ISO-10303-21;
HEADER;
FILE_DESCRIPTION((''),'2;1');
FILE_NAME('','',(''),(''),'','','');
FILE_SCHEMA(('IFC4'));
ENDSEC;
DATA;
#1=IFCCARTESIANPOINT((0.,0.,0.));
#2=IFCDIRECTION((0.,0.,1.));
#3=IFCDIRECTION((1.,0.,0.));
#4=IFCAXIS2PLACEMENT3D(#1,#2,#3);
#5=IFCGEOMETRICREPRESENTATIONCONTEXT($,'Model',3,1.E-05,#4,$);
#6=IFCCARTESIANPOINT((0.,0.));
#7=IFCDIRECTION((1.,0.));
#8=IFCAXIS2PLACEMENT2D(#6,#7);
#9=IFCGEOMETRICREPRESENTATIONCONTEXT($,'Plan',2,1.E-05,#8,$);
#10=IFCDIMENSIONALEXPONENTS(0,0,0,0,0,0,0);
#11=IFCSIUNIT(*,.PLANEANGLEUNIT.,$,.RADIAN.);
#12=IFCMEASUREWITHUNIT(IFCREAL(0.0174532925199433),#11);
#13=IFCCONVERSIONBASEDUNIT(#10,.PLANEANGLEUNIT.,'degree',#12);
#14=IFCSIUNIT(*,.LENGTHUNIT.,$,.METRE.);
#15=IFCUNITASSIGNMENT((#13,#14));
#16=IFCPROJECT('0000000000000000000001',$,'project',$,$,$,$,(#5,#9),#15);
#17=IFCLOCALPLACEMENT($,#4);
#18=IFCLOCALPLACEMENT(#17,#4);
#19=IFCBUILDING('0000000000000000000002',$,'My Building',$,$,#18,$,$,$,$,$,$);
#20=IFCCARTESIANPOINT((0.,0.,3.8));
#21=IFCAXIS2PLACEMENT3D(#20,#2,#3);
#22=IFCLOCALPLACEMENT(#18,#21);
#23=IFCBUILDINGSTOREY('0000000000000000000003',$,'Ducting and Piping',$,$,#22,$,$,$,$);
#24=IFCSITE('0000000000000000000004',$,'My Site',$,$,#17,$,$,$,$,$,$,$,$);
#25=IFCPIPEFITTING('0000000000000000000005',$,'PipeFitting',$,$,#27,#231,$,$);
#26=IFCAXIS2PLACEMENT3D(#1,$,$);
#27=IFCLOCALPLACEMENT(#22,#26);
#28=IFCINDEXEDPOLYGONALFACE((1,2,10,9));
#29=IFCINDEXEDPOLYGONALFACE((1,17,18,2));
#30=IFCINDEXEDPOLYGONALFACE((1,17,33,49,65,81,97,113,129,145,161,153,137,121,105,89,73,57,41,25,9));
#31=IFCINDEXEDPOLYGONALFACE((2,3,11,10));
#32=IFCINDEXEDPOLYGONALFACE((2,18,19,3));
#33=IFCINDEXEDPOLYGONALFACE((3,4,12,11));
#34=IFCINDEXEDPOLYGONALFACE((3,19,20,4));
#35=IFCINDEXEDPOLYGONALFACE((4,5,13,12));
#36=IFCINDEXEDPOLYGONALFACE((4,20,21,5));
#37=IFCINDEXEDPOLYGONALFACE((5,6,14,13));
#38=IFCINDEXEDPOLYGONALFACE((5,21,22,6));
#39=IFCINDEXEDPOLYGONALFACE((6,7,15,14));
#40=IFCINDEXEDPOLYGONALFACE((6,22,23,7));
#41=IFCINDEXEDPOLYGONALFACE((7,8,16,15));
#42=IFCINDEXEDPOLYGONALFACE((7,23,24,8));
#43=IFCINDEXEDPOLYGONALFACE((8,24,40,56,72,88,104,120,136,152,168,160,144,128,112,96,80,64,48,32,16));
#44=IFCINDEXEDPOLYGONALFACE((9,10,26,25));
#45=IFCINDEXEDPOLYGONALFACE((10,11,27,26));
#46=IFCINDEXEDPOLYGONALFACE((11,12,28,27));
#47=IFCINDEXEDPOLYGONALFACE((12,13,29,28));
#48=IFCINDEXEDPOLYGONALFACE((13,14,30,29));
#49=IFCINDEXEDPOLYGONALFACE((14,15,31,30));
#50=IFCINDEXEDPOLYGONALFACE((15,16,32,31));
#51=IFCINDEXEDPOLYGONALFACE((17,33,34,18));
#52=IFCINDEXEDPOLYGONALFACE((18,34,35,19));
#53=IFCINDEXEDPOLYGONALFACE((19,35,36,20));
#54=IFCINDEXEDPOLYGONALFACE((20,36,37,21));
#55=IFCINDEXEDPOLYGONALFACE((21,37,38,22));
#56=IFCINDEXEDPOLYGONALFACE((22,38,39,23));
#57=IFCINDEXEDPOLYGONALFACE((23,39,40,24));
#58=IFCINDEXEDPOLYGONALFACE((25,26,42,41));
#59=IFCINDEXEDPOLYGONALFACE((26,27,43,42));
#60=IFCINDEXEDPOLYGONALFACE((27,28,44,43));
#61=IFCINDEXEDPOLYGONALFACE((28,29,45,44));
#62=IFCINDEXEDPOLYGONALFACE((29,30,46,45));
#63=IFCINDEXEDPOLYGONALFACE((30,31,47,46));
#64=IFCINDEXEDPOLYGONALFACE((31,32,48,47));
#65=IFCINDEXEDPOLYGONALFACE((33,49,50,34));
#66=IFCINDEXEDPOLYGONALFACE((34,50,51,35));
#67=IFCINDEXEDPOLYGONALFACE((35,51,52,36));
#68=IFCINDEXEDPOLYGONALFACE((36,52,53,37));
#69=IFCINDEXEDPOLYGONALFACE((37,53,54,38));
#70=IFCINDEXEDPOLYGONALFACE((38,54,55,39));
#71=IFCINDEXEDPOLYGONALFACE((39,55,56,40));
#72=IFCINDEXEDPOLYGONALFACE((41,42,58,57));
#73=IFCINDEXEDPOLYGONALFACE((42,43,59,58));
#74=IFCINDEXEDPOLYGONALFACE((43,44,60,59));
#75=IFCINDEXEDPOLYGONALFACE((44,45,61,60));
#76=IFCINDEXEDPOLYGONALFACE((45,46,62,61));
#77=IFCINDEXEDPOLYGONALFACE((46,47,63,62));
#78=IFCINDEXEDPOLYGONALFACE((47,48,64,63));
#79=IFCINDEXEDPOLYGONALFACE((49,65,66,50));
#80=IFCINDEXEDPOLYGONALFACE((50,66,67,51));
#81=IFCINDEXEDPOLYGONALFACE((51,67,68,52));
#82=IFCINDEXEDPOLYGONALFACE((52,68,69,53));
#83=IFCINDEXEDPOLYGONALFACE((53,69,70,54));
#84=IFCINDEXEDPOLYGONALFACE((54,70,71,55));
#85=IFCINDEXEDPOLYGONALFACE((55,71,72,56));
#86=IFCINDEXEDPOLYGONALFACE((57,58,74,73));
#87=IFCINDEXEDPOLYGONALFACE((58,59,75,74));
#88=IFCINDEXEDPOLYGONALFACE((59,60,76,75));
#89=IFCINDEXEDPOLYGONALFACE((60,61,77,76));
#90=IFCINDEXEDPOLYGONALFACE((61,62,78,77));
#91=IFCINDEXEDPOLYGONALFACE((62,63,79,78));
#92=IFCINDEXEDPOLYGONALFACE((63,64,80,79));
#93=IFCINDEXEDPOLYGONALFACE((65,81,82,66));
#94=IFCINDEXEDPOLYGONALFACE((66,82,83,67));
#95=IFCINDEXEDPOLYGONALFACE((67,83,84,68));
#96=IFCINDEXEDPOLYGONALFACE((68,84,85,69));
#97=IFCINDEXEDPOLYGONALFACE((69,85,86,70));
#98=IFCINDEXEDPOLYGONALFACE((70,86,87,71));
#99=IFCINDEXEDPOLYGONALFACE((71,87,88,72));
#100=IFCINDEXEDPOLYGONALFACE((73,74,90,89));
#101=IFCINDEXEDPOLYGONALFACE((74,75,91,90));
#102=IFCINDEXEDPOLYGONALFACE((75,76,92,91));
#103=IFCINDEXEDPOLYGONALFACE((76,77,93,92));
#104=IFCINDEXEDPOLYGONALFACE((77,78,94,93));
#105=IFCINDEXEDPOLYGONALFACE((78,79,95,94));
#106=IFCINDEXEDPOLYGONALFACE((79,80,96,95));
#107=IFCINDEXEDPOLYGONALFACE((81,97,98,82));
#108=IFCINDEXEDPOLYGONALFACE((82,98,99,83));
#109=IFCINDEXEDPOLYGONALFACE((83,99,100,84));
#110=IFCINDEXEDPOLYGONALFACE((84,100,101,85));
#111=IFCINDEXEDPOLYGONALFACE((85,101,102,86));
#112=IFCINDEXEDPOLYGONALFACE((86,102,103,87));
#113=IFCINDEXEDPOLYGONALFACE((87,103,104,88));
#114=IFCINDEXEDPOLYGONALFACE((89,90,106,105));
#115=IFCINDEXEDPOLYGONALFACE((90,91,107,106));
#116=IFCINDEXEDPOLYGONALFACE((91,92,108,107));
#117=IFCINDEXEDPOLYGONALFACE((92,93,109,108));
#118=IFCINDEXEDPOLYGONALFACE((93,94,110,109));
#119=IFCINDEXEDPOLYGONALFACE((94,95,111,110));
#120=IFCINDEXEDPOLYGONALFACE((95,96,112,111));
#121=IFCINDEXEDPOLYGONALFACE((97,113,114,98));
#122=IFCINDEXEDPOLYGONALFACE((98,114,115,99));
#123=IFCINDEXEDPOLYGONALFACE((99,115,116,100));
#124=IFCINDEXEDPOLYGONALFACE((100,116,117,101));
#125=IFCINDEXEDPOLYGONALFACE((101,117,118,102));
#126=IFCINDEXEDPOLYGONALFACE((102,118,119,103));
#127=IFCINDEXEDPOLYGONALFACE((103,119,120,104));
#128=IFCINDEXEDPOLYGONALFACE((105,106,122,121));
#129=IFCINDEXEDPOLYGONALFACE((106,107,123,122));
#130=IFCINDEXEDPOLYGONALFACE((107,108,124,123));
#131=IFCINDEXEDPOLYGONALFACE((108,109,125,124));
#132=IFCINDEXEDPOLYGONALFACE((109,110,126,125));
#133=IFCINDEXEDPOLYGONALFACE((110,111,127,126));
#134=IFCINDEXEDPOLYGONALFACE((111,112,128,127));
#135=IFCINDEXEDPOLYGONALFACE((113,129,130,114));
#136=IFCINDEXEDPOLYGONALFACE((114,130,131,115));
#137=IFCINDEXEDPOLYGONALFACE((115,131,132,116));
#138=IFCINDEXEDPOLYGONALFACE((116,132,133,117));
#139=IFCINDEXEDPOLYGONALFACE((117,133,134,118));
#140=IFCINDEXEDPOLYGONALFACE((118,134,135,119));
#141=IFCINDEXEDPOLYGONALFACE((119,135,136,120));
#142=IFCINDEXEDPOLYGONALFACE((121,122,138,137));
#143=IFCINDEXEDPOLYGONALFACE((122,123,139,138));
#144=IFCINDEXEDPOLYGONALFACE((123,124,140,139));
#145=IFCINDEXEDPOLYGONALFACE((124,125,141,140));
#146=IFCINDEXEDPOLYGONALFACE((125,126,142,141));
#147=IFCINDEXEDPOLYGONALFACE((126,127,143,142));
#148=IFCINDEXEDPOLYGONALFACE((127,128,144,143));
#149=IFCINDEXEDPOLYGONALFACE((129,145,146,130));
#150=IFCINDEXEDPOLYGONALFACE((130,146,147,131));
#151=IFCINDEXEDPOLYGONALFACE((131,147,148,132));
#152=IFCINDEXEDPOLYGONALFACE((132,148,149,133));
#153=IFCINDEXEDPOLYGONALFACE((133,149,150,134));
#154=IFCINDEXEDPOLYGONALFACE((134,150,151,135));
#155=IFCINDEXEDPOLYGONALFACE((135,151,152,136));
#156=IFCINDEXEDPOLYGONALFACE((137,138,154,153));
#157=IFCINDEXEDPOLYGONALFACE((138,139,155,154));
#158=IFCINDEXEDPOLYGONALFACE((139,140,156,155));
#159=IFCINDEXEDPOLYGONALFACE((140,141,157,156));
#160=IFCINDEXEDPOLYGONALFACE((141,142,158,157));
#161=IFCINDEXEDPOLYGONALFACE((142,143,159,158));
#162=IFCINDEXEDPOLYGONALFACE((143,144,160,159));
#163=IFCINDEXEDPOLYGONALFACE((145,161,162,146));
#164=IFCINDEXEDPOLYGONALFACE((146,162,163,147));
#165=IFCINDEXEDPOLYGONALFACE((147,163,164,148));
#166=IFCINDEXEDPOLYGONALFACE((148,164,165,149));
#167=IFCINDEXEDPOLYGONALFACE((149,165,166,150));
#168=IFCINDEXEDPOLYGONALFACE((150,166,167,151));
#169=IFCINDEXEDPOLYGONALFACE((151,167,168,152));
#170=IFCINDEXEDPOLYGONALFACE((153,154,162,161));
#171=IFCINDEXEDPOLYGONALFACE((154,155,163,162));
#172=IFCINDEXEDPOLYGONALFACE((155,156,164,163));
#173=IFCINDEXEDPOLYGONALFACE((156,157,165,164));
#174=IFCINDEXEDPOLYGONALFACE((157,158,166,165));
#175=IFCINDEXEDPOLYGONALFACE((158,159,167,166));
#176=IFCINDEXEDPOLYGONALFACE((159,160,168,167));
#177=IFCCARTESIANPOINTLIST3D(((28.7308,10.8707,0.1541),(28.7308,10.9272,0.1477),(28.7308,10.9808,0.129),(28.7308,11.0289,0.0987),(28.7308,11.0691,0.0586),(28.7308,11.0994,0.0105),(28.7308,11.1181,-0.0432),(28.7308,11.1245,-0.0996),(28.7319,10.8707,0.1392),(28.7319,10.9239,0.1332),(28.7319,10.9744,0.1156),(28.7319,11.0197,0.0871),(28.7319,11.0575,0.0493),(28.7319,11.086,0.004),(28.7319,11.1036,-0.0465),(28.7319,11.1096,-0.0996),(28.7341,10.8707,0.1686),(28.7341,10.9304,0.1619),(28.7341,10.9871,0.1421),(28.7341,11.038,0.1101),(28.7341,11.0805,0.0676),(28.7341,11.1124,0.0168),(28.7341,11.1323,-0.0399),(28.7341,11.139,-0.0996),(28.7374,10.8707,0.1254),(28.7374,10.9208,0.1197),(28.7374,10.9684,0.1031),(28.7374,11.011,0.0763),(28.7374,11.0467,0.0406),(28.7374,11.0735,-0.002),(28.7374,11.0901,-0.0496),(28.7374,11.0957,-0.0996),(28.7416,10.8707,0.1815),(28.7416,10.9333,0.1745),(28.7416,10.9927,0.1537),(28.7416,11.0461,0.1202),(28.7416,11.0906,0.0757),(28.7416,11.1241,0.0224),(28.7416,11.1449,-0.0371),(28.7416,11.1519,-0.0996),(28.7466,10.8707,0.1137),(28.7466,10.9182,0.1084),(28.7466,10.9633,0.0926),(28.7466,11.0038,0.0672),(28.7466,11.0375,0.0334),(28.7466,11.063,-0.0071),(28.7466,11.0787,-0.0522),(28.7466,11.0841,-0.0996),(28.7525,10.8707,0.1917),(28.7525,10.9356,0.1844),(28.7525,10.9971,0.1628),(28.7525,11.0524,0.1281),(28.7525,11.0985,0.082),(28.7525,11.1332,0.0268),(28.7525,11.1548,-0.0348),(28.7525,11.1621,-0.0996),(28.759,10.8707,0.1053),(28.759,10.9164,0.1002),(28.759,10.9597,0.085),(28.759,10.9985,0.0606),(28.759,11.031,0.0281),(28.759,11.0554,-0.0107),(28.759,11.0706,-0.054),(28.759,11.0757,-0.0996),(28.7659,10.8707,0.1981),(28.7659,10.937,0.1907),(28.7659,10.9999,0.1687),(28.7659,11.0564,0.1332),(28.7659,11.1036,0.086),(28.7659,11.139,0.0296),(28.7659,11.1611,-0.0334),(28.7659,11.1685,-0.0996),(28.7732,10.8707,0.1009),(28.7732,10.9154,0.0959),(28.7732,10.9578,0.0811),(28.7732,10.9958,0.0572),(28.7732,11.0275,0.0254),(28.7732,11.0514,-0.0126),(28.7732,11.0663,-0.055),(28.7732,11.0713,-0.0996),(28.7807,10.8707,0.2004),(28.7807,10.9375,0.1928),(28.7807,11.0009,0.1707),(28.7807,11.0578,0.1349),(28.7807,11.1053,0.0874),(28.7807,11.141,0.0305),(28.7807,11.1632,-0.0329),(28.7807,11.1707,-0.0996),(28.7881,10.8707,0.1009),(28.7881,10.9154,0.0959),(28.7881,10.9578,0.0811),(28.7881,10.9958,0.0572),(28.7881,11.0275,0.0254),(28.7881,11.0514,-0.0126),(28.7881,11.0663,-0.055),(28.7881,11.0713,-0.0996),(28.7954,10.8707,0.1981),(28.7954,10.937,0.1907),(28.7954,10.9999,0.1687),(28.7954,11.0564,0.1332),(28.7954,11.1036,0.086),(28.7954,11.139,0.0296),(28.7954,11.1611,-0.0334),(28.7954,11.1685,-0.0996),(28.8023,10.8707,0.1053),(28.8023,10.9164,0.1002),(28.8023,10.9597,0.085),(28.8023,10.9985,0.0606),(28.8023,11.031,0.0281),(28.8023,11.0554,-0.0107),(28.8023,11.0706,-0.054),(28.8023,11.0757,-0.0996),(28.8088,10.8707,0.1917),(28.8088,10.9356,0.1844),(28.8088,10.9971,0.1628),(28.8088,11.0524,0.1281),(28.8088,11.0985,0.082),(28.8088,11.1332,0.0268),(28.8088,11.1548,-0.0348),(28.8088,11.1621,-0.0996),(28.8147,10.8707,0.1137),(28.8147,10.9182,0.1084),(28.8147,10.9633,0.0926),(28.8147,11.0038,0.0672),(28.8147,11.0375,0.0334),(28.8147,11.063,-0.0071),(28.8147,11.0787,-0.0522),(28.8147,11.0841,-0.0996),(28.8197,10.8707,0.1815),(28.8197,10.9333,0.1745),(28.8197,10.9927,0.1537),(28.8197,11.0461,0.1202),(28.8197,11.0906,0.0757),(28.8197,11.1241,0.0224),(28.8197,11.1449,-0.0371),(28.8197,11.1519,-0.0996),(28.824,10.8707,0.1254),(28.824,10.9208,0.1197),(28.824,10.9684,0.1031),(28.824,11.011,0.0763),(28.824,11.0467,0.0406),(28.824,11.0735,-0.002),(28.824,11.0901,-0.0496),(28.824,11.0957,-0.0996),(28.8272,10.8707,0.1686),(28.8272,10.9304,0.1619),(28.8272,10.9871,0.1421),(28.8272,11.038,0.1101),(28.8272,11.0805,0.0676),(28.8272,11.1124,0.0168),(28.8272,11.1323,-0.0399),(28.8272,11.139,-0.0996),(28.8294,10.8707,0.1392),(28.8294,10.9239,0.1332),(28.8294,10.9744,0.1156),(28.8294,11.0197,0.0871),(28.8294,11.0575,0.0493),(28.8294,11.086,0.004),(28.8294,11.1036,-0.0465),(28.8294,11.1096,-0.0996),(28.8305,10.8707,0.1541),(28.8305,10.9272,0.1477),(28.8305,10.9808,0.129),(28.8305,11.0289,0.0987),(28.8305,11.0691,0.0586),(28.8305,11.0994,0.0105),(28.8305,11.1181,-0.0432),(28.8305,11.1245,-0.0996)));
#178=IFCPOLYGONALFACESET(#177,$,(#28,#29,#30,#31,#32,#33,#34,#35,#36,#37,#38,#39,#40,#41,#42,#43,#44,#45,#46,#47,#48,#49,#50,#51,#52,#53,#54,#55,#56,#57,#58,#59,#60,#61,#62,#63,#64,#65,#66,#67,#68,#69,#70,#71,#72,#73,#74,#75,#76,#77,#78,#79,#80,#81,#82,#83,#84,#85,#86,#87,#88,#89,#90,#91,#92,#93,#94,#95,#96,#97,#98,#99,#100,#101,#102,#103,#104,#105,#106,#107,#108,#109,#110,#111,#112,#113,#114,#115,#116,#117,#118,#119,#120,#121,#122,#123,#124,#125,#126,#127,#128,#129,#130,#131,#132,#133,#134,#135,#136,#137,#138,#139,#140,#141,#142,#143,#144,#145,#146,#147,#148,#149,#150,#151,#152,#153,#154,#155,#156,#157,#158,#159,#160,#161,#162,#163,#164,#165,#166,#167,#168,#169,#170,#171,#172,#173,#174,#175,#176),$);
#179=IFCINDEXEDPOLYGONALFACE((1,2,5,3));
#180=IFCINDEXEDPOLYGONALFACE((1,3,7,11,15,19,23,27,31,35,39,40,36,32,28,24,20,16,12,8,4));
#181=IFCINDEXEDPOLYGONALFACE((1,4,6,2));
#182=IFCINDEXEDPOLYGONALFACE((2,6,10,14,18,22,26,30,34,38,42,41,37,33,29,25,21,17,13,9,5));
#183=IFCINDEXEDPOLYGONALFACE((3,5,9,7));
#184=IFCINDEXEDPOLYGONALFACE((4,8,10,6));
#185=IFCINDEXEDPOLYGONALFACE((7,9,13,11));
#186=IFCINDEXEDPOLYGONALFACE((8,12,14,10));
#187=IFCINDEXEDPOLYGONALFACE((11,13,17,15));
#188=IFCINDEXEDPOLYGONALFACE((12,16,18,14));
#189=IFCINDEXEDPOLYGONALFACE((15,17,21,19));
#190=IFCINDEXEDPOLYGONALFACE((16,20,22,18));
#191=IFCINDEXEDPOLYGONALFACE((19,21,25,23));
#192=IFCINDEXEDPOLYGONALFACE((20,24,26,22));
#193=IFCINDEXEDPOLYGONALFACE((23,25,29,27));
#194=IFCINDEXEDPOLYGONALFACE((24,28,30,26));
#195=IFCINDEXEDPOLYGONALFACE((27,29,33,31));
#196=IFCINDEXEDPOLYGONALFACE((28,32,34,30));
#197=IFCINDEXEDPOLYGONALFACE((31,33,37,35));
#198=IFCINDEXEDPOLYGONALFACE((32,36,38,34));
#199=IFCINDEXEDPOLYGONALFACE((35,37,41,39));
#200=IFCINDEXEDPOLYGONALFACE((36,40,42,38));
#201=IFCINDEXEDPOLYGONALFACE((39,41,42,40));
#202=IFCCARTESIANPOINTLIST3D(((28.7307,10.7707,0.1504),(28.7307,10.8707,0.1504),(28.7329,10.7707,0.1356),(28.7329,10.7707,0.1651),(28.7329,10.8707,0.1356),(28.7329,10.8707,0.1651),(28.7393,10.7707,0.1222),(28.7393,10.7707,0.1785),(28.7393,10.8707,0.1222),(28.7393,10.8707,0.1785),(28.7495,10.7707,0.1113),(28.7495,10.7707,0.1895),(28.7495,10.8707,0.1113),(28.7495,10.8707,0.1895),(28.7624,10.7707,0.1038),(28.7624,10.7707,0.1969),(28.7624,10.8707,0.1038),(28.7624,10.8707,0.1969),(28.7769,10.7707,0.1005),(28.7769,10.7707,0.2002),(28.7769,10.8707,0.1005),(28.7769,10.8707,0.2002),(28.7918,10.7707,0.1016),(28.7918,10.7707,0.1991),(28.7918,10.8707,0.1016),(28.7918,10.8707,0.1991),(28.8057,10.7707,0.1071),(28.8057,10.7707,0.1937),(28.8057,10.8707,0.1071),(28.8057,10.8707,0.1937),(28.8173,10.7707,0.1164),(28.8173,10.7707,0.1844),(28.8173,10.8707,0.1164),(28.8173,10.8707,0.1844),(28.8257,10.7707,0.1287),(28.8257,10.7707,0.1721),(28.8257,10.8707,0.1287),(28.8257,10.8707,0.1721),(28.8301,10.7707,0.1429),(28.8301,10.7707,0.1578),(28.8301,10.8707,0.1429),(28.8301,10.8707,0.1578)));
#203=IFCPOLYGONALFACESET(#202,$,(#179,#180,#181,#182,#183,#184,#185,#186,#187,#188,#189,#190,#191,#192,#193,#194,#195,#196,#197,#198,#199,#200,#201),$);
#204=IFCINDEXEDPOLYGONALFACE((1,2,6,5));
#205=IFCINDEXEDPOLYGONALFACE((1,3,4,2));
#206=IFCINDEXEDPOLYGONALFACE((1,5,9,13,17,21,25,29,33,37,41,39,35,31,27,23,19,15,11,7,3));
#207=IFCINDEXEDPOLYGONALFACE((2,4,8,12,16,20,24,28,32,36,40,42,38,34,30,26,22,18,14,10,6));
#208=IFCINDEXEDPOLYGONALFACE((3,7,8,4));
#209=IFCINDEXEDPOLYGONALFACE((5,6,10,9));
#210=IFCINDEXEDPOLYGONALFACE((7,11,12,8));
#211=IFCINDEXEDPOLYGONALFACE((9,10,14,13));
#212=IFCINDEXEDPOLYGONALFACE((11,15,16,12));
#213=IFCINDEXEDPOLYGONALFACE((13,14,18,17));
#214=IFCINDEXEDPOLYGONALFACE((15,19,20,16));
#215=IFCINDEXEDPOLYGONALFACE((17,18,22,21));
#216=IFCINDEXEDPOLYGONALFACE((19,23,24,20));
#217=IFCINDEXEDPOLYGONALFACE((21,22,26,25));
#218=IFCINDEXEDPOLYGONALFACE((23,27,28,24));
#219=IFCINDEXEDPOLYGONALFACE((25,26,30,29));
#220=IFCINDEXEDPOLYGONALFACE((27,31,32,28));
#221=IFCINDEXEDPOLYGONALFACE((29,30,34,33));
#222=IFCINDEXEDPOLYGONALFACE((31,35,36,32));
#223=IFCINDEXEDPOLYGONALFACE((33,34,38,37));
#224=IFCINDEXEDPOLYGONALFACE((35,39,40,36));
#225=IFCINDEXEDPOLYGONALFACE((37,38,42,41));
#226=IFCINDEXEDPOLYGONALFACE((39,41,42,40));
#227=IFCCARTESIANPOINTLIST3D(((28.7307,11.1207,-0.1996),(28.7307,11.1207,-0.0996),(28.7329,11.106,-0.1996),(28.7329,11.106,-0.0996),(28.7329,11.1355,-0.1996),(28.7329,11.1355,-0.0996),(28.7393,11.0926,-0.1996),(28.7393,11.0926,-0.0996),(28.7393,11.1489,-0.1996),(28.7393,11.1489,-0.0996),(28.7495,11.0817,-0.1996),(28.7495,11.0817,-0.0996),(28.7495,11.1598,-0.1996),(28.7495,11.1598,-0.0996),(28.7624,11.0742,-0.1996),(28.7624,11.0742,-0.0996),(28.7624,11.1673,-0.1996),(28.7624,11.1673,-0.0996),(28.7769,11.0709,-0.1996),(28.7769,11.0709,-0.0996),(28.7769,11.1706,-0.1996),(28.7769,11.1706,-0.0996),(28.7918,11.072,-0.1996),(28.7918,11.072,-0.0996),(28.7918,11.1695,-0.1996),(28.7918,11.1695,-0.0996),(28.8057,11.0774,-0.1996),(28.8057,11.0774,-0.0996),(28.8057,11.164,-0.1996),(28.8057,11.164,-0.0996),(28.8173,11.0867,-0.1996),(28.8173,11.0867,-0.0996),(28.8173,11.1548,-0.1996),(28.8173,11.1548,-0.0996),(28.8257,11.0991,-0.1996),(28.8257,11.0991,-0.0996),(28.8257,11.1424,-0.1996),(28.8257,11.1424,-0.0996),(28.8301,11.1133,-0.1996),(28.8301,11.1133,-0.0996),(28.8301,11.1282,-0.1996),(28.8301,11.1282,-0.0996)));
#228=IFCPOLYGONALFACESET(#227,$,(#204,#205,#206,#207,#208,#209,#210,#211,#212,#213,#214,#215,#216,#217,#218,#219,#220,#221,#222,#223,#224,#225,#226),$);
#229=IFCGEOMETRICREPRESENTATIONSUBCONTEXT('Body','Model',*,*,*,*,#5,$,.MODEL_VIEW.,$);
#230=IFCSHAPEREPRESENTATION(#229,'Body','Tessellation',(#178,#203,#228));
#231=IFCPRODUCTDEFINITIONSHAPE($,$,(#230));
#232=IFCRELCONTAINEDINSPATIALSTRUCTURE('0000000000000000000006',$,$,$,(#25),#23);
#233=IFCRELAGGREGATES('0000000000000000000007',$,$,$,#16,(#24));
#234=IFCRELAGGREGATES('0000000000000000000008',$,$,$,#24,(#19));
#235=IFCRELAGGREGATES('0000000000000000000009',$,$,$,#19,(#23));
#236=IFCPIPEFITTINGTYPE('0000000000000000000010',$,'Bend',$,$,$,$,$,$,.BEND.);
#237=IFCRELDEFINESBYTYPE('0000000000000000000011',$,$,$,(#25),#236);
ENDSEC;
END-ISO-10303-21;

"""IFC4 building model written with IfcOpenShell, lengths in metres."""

from ifc_helpers import new_model, entity, si_unit, converted_unit, frame, origin_with_axes, origin_2d_with_axis, place, context, subcontext, project, spatial, circle, extrude, source, transform, mapped, type_object, type_shapes, element, save


model = new_model("IFC4")

# Units and contexts
model_context = context("Model", 3, precision=1e-05, world=origin_with_axes())
plan_context = context("Plan", 2, precision=1e-05, world=origin_2d_with_axis())
body_context = subcontext(model_context, "Body", "Model", "MODEL_VIEW")
ifc_project = project(units=[converted_unit("PLANEANGLEUNIT", "degree", entity("IfcReal", 0.0174532925199433), si_unit("PLANEANGLEUNIT", "RADIAN"), dimensions=[0, 0, 0, 0, 0, 0, 0]), si_unit("LENGTHUNIT", "METRE")], contexts=[model_context, plan_context])

# Site, building, storey
site_placement = place(None, origin_with_axes())
site = spatial("IfcSite", under=ifc_project, at=site_placement, Name="My Site")
building_placement = place(site_placement, origin_with_axes())
building = spatial("IfcBuilding", under=site, at=building_placement, Name="My Building")
storey_placement = place(building_placement, frame((0.0, 0.0, 3.8), z_axis=(0.0, 0.0, 1.0), x_axis=(1.0, 0.0, 0.0)))
storey = spatial("IfcBuildingStorey", under=building, at=storey_placement, Name="Ducting and Piping")

# Pipe fitting
pipe_fitting_type = type_object("IfcPipeFittingType", Name="Bend", PredefinedType="BEND")
shared_shape = source(origin_with_axes(), body_context, "Body", "SolidModel", [
    entity("IfcSweptDiskSolid", entity("IfcIndexedPolyCurve", entity("IfcCartesianPointList3D", [[0.0, 0.0, 0.1], [0.0, -0.0732, 0.2768], [0.0, -0.25, 0.35]]), [entity("IfcArcIndex", [1, 2, 3])]), 0.05),
    extrude(circle(Radius=0.05), origin_with_axes(), (0.0, 0.0, 1.0), 0.1),
    extrude(circle(Radius=0.05), frame((0.0, -0.25, 0.35), z_axis=(0.0, -1.0, 0.0), x_axis=(1.0, 0.0, 0.0)), (0.0, 0.0, 1.0), 0.1),
])
type_shapes(pipe_fitting_type, [shared_shape])
for number, where, z_axis, x_axis, name in (
    (1, (28.7807, 10.7707, 0.1504), (0.0, 1.0, 0.0), (-1.0, 0.0, 0.0), "PipeFitting"),
):
    element("IfcPipeFitting", number, at=place(storey_placement, frame(where, z_axis=z_axis, x_axis=x_axis)), inside=storey, type_object=pipe_fitting_type, Name=name, context=body_context, shape_type="MappedRepresentation", body=[
        mapped(shared_shape, transform((0.0, 0.0, 0.0), x_axis=(1.0, 0.0, 0.0), y_axis=(0.0, 1.0, 0.0), z_axis=(0.0, 0.0, 1.0), scale=1.0)),
    ])

save(model, "model.ifc")
